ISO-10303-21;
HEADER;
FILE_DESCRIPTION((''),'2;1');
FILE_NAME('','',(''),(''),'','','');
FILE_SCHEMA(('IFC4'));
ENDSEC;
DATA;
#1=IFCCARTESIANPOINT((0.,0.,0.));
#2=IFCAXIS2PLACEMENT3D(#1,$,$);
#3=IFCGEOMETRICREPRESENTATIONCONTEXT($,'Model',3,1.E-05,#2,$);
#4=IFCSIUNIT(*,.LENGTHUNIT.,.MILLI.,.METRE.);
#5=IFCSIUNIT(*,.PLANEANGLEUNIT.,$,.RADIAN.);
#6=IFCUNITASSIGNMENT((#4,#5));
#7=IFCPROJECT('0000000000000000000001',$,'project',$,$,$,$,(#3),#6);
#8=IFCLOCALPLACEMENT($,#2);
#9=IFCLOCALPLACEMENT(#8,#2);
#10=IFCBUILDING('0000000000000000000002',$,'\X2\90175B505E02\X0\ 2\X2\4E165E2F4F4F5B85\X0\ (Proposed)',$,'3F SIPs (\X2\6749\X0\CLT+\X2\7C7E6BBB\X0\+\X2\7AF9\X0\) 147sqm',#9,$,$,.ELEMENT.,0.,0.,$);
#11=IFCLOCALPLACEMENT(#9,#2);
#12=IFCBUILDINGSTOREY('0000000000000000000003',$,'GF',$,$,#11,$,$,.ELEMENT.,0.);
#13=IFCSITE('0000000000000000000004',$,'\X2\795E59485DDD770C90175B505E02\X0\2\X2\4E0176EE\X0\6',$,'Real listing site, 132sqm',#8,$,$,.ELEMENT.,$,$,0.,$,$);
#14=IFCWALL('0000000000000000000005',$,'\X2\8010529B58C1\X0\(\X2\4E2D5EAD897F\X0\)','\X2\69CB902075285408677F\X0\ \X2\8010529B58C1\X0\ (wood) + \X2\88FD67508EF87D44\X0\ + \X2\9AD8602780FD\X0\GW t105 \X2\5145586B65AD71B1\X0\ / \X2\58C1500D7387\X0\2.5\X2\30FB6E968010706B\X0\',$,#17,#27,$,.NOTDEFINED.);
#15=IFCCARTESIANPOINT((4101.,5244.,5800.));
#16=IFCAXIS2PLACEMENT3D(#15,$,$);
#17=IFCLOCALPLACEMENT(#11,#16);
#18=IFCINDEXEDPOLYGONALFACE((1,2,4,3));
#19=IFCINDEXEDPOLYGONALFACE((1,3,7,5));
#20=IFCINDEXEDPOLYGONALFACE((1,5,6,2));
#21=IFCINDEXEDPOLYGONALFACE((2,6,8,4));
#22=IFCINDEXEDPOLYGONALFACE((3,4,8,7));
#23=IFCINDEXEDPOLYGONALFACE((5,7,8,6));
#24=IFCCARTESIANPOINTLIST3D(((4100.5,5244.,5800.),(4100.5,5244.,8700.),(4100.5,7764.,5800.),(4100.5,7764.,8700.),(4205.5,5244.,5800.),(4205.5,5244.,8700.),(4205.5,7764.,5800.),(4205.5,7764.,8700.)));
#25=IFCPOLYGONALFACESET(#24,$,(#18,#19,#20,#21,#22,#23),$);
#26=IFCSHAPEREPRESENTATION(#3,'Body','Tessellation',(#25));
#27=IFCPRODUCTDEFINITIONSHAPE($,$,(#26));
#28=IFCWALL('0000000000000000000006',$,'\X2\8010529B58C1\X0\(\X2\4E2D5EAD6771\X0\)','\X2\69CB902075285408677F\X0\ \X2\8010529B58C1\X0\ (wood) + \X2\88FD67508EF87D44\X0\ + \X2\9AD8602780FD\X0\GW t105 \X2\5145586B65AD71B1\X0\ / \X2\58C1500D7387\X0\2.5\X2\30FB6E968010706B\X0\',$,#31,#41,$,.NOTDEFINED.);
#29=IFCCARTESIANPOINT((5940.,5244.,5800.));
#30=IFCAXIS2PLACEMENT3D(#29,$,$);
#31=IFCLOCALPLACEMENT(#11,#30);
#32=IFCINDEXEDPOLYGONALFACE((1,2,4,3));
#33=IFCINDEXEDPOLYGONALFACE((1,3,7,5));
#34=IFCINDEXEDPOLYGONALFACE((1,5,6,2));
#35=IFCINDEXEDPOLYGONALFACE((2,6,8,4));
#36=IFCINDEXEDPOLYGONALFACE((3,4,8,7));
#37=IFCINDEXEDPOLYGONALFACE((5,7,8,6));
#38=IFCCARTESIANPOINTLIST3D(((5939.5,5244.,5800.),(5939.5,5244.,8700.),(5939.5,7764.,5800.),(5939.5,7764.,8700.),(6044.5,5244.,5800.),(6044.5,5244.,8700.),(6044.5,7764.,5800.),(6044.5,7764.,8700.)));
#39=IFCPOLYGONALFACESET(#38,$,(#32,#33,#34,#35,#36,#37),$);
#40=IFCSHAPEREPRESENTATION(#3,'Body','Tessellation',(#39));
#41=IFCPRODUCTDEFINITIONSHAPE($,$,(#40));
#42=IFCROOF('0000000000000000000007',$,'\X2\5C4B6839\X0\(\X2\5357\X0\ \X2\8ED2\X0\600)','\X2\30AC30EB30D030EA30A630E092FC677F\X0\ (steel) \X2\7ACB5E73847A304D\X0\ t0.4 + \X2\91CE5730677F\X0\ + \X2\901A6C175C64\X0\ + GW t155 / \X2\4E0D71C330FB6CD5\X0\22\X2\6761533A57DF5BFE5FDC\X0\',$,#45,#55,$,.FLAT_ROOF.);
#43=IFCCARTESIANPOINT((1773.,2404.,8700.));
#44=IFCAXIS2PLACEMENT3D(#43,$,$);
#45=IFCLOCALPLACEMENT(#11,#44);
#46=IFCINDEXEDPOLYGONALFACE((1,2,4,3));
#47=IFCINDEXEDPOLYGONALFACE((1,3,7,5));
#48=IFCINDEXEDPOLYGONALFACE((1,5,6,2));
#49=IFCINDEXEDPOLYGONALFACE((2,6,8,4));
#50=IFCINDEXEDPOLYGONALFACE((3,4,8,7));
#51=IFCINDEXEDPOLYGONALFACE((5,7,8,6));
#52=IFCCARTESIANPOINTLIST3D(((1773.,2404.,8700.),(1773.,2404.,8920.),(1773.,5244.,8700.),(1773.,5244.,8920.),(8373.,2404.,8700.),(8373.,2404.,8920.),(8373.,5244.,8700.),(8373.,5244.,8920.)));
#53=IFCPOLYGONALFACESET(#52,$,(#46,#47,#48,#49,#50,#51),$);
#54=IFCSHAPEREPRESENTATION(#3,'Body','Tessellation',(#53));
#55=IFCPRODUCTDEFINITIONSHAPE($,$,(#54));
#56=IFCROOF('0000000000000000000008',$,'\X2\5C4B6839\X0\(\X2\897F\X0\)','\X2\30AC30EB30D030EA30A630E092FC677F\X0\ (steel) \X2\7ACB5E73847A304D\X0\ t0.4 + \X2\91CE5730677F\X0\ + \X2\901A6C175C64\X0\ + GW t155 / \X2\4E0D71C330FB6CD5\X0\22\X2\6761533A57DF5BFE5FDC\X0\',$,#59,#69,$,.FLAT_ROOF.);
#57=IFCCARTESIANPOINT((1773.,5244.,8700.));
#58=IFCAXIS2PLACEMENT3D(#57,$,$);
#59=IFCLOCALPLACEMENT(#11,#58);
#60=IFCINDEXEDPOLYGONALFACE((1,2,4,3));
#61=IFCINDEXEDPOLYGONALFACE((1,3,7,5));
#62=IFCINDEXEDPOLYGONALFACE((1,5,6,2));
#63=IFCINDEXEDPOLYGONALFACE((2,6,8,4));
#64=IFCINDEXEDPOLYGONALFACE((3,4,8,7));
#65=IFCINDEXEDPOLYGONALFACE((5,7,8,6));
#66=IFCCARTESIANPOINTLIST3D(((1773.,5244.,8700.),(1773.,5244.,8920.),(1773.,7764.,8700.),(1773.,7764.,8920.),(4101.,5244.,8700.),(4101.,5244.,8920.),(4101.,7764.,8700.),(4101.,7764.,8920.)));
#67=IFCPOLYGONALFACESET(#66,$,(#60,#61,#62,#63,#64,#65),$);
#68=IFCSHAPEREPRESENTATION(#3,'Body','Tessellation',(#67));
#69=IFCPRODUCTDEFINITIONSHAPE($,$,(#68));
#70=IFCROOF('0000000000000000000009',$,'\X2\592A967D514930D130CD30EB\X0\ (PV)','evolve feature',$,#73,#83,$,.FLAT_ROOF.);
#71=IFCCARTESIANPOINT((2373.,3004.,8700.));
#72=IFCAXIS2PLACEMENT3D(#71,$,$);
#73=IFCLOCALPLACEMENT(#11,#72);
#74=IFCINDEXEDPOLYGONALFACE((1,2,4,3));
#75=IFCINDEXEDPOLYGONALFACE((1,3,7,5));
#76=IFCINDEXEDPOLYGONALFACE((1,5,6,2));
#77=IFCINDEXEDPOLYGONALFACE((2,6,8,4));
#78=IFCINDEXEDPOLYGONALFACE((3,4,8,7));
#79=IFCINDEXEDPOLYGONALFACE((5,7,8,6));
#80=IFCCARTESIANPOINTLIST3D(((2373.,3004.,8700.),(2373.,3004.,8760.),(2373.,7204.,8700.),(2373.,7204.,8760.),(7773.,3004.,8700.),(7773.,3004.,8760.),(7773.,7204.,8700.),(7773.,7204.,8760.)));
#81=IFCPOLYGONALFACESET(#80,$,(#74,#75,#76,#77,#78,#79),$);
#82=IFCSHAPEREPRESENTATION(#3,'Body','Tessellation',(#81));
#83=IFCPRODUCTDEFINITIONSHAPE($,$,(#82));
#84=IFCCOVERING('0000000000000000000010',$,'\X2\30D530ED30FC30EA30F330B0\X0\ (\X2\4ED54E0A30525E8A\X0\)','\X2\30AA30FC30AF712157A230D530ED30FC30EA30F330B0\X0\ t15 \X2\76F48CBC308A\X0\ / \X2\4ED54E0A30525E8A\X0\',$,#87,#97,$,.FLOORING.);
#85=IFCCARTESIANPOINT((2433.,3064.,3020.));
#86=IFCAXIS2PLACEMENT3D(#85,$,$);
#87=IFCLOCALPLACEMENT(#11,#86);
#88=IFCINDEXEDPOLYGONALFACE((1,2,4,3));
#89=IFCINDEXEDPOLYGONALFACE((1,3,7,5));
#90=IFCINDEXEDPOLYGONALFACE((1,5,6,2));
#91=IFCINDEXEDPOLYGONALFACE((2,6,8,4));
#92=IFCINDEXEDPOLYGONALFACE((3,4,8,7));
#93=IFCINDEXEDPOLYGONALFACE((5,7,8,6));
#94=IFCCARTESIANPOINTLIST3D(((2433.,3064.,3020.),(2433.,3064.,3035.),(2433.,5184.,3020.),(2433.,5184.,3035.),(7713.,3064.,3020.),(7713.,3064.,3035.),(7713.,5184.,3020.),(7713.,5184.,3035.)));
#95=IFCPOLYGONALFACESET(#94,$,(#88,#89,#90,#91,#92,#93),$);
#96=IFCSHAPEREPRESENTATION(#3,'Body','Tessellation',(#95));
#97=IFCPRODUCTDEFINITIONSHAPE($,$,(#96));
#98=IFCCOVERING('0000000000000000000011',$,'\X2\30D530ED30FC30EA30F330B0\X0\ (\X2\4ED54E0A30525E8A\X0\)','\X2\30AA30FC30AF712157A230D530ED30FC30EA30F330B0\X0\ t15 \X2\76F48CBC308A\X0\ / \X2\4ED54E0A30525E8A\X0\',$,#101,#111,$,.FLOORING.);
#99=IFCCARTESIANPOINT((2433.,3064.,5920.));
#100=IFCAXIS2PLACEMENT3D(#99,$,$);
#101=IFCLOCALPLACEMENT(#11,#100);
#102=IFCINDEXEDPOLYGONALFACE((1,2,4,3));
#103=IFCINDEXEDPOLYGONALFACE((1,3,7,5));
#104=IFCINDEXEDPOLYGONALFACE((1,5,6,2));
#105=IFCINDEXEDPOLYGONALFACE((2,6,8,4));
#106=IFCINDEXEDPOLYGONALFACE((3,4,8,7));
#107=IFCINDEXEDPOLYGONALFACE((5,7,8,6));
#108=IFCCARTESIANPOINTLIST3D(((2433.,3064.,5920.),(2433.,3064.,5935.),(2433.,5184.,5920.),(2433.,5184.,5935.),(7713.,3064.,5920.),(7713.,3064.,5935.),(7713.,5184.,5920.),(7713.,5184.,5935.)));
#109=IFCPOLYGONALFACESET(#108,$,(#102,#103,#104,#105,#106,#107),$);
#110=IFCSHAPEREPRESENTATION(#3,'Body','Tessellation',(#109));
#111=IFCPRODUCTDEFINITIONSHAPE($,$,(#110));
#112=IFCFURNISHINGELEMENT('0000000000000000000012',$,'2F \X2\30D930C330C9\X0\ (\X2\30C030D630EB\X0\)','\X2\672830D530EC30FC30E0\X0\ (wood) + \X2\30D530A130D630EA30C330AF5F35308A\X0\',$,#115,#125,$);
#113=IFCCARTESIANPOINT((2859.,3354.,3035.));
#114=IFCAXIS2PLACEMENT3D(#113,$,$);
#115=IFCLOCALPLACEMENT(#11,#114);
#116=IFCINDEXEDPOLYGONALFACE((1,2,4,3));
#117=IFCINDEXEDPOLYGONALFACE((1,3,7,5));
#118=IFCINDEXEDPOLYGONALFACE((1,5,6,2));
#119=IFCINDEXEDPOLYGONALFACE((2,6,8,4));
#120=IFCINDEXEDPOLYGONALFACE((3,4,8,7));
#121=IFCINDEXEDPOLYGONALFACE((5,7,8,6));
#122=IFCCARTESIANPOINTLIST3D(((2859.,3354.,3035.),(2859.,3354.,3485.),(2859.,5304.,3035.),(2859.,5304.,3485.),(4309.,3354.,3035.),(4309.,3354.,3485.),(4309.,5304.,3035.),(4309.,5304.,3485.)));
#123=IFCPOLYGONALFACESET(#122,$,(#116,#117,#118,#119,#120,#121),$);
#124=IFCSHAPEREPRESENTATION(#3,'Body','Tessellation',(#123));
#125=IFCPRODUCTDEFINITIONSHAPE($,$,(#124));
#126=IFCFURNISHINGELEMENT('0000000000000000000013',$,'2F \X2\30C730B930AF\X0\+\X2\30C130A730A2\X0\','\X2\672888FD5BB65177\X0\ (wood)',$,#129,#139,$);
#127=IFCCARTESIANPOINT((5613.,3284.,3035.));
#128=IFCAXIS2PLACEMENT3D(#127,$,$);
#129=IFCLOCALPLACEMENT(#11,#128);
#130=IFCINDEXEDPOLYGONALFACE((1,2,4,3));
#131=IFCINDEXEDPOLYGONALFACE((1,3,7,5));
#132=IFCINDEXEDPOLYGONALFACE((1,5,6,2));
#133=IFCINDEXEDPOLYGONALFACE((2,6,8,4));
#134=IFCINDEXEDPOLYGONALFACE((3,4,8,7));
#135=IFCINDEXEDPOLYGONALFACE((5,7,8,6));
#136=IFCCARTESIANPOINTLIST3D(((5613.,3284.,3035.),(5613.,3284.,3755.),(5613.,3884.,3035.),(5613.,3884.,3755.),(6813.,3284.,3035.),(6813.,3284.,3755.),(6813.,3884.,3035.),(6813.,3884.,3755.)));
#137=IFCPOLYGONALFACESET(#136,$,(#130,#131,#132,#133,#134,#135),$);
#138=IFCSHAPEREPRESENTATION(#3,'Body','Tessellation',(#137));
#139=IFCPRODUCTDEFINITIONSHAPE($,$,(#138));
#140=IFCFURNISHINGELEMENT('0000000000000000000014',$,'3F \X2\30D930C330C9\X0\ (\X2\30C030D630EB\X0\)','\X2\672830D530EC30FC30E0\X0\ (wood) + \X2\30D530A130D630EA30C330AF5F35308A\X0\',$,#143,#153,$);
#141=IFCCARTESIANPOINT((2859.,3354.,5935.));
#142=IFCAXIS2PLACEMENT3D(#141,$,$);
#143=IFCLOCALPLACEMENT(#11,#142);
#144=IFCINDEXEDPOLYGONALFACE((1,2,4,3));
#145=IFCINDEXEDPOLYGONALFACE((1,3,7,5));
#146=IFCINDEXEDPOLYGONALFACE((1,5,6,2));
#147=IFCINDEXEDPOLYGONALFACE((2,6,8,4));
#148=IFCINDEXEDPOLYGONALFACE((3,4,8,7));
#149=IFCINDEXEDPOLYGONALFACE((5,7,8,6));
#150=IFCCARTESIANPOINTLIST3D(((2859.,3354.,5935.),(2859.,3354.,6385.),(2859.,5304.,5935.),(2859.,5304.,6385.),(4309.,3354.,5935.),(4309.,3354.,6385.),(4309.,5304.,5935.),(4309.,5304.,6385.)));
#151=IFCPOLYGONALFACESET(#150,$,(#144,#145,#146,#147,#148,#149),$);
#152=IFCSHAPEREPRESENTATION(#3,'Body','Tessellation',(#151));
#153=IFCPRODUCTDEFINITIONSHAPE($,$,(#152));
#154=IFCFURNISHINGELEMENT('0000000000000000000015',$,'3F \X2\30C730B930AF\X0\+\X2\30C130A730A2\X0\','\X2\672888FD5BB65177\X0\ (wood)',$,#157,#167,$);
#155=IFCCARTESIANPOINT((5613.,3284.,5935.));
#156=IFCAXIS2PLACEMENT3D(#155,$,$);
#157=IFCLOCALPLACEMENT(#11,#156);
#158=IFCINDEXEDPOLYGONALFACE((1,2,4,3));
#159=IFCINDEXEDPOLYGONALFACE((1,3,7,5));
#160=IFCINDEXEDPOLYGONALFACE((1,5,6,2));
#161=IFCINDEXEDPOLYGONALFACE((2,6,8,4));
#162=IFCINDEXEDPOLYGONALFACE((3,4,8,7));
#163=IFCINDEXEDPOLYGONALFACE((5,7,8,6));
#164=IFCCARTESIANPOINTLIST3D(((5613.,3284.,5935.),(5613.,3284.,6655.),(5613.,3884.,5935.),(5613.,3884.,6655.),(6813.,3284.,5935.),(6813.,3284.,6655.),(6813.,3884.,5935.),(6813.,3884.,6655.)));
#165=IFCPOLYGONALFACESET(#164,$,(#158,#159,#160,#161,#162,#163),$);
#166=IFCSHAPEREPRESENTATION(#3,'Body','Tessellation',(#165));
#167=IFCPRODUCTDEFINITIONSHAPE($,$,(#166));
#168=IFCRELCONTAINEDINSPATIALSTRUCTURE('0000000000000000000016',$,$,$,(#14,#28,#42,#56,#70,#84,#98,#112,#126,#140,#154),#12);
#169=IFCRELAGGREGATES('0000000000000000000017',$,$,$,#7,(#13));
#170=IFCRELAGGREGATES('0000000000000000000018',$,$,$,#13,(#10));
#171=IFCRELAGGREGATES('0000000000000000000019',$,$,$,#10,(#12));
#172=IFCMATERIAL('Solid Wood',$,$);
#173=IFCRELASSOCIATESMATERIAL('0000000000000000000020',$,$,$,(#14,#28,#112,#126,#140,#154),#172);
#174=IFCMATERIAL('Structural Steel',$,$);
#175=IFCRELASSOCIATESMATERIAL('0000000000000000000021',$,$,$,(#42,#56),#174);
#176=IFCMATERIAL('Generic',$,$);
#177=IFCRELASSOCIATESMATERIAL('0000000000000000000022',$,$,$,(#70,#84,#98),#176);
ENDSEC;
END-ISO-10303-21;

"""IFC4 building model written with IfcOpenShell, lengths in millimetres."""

from ifc_helpers import new_model, si_unit, frame, frame_2d, origin, place, context, project, spatial, rectangle, extrude, material, element, save


model = new_model("IFC4")

# Units and contexts
model_context = context("Model", 3, precision=1e-05, world=origin())
ifc_project = project(units=[si_unit("LENGTHUNIT", "METRE", prefix="MILLI"), si_unit("PLANEANGLEUNIT", "RADIAN")], contexts=[model_context])

# Site, building, storey
site_placement = place(None, origin())
site = spatial("IfcSite", under=ifc_project, at=site_placement, Name="神奈川県逗子市2丁目6", ObjectType="Real listing site, 132sqm", CompositionType="ELEMENT", RefElevation=0.0)
building_placement = place(site_placement, origin())
building = spatial("IfcBuilding", under=site, at=building_placement, Name="逗子市 2世帯住宅 (Proposed)", ObjectType="3F SIPs (杉CLT+籾殻+竹) 147sqm", CompositionType="ELEMENT", ElevationOfRefHeight=0.0, ElevationOfTerrain=0.0)
storey_placement = place(building_placement, origin())
storey = spatial("IfcBuildingStorey", under=building, at=storey_placement, Name="GF", CompositionType="ELEMENT", Elevation=0.0)

# Shared definitions
ifc_material_1 = material(Name="Solid Wood")

# Walls
wall_1_placement = place(storey_placement, frame((4101.0, 5244.0, 5800.0)))
element("IfcWall", 1, at=wall_1_placement, inside=storey, material=ifc_material_1, Name="耐力壁(中庭西)", Description="構造用合板 耐力壁 (wood) + 製材軸組 + 高性能GW t105 充填断熱 / 壁倍率2.5・準耐火", PredefinedType="NOTDEFINED", context=model_context, shape_type="SweptSolid", body=[
    extrude(rectangle(XDim=105.0, YDim=2520.0, at=frame_2d((52.0, 1260.0))), frame((4101.0, 5244.0, 5800.0)), (0.0, 0.0, 1.0), 2900.0),
])
wall_2_placement = place(storey_placement, frame((5940.0, 5244.0, 5800.0)))
element("IfcWall", 2, at=wall_2_placement, inside=storey, material=ifc_material_1, Name="耐力壁(中庭東)", Description="構造用合板 耐力壁 (wood) + 製材軸組 + 高性能GW t105 充填断熱 / 壁倍率2.5・準耐火", PredefinedType="NOTDEFINED", context=model_context, shape_type="SweptSolid", body=[
    extrude(rectangle(XDim=105.0, YDim=2520.0, at=frame_2d((52.0, 1260.0))), frame((5940.0, 5244.0, 5800.0)), (0.0, 0.0, 1.0), 2900.0),
])

# Roofs
ifc_material_2 = material(Name="Structural Steel")
roof_1_placement = place(storey_placement, frame((1773.0, 2404.0, 8700.0)))
element("IfcRoof", 3, at=roof_1_placement, inside=storey, material=ifc_material_2, Name="屋根(南 軒600)", Description="ガルバリウム鋼板 (steel) 立平葺き t0.4 + 野地板 + 通気層 + GW t155 / 不燃・法22条区域対応", PredefinedType="FLAT_ROOF", context=model_context, shape_type="SweptSolid", body=[
    extrude(rectangle(XDim=6600.0, YDim=2840.0, at=frame_2d((3300.0, 1420.0))), frame((1773.0, 2404.0, 8700.0)), (0.0, 0.0, 1.0), 220.0),
])
roof_2_placement = place(storey_placement, frame((1773.0, 5244.0, 8700.0)))
element("IfcRoof", 4, at=roof_2_placement, inside=storey, material=ifc_material_2, Name="屋根(西)", Description="ガルバリウム鋼板 (steel) 立平葺き t0.4 + 野地板 + 通気層 + GW t155 / 不燃・法22条区域対応", PredefinedType="FLAT_ROOF", context=model_context, shape_type="SweptSolid", body=[
    extrude(rectangle(XDim=2328.0, YDim=2520.0, at=frame_2d((1164.0, 1260.0))), frame((1773.0, 5244.0, 8700.0)), (0.0, 0.0, 1.0), 220.0),
])
ifc_material_3 = material(Name="Generic")
roof_3_placement = place(storey_placement, frame((2373.0, 3004.0, 8700.0)))
element("IfcRoof", 5, at=roof_3_placement, inside=storey, material=ifc_material_3, Name="太陽光パネル (PV)", Description="evolve feature", PredefinedType="FLAT_ROOF", context=model_context, shape_type="SweptSolid", body=[
    extrude(rectangle(XDim=5400.0, YDim=4200.0, at=frame_2d((2700.0, 2100.0))), frame((2373.0, 3004.0, 8700.0)), (0.0, 0.0, 1.0), 60.0),
])

# Coverings
covering_1_placement = place(storey_placement, frame((2433.0, 3064.0, 3020.0)))
element("IfcCovering", 6, at=covering_1_placement, inside=storey, material=ifc_material_3, Name="フローリング (仕上げ床)", Description="オーク無垢フローリング t15 直貼り / 仕上げ床", PredefinedType="FLOORING", context=model_context, shape_type="SweptSolid", body=[
    extrude(rectangle(XDim=5280.0, YDim=2120.0, at=frame_2d((2640.0, 1060.0))), frame((2433.0, 3064.0, 3020.0)), (0.0, 0.0, 1.0), 15.0),
])
covering_2_placement = place(storey_placement, frame((2433.0, 3064.0, 5920.0)))
element("IfcCovering", 7, at=covering_2_placement, inside=storey, material=ifc_material_3, Name="フローリング (仕上げ床)", Description="オーク無垢フローリング t15 直貼り / 仕上げ床", PredefinedType="FLOORING", context=model_context, shape_type="SweptSolid", body=[
    extrude(rectangle(XDim=5280.0, YDim=2120.0, at=frame_2d((2640.0, 1060.0))), frame((2433.0, 3064.0, 5920.0)), (0.0, 0.0, 1.0), 15.0),
])

# Furnishing elements
furnishing_1_placement = place(storey_placement, frame((2859.0, 3354.0, 3035.0)))
element("IfcFurnishingElement", 8, at=furnishing_1_placement, inside=storey, material=ifc_material_1, Name="2F ベッド (ダブル)", Description="木フレーム (wood) + ファブリック張り", context=model_context, shape_type="SweptSolid", body=[
    extrude(rectangle(XDim=1450.0, YDim=1950.0, at=frame_2d((725.0, 975.0))), frame((2859.0, 3354.0, 3035.0)), (0.0, 0.0, 1.0), 450.0),
])
furnishing_2_placement = place(storey_placement, frame((5613.0, 3284.0, 3035.0)))
element("IfcFurnishingElement", 9, at=furnishing_2_placement, inside=storey, material=ifc_material_1, Name="2F デスク+チェア", Description="木製家具 (wood)", context=model_context, shape_type="SweptSolid", body=[
    extrude(rectangle(XDim=1200.0, YDim=600.0, at=frame_2d((600.0, 300.0))), frame((5613.0, 3284.0, 3035.0)), (0.0, 0.0, 1.0), 720.0),
])
furnishing_3_placement = place(storey_placement, frame((2859.0, 3354.0, 5935.0)))
element("IfcFurnishingElement", 10, at=furnishing_3_placement, inside=storey, material=ifc_material_1, Name="3F ベッド (ダブル)", Description="木フレーム (wood) + ファブリック張り", context=model_context, shape_type="SweptSolid", body=[
    extrude(rectangle(XDim=1450.0, YDim=1950.0, at=frame_2d((725.0, 975.0))), frame((2859.0, 3354.0, 5935.0)), (0.0, 0.0, 1.0), 450.0),
])
furnishing_4_placement = place(storey_placement, frame((5613.0, 3284.0, 5935.0)))
element("IfcFurnishingElement", 11, at=furnishing_4_placement, inside=storey, material=ifc_material_1, Name="3F デスク+チェア", Description="木製家具 (wood)", context=model_context, shape_type="SweptSolid", body=[
    extrude(rectangle(XDim=1200.0, YDim=600.0, at=frame_2d((600.0, 300.0))), frame((5613.0, 3284.0, 5935.0)), (0.0, 0.0, 1.0), 720.0),
])

save(model, "model.ifc")
